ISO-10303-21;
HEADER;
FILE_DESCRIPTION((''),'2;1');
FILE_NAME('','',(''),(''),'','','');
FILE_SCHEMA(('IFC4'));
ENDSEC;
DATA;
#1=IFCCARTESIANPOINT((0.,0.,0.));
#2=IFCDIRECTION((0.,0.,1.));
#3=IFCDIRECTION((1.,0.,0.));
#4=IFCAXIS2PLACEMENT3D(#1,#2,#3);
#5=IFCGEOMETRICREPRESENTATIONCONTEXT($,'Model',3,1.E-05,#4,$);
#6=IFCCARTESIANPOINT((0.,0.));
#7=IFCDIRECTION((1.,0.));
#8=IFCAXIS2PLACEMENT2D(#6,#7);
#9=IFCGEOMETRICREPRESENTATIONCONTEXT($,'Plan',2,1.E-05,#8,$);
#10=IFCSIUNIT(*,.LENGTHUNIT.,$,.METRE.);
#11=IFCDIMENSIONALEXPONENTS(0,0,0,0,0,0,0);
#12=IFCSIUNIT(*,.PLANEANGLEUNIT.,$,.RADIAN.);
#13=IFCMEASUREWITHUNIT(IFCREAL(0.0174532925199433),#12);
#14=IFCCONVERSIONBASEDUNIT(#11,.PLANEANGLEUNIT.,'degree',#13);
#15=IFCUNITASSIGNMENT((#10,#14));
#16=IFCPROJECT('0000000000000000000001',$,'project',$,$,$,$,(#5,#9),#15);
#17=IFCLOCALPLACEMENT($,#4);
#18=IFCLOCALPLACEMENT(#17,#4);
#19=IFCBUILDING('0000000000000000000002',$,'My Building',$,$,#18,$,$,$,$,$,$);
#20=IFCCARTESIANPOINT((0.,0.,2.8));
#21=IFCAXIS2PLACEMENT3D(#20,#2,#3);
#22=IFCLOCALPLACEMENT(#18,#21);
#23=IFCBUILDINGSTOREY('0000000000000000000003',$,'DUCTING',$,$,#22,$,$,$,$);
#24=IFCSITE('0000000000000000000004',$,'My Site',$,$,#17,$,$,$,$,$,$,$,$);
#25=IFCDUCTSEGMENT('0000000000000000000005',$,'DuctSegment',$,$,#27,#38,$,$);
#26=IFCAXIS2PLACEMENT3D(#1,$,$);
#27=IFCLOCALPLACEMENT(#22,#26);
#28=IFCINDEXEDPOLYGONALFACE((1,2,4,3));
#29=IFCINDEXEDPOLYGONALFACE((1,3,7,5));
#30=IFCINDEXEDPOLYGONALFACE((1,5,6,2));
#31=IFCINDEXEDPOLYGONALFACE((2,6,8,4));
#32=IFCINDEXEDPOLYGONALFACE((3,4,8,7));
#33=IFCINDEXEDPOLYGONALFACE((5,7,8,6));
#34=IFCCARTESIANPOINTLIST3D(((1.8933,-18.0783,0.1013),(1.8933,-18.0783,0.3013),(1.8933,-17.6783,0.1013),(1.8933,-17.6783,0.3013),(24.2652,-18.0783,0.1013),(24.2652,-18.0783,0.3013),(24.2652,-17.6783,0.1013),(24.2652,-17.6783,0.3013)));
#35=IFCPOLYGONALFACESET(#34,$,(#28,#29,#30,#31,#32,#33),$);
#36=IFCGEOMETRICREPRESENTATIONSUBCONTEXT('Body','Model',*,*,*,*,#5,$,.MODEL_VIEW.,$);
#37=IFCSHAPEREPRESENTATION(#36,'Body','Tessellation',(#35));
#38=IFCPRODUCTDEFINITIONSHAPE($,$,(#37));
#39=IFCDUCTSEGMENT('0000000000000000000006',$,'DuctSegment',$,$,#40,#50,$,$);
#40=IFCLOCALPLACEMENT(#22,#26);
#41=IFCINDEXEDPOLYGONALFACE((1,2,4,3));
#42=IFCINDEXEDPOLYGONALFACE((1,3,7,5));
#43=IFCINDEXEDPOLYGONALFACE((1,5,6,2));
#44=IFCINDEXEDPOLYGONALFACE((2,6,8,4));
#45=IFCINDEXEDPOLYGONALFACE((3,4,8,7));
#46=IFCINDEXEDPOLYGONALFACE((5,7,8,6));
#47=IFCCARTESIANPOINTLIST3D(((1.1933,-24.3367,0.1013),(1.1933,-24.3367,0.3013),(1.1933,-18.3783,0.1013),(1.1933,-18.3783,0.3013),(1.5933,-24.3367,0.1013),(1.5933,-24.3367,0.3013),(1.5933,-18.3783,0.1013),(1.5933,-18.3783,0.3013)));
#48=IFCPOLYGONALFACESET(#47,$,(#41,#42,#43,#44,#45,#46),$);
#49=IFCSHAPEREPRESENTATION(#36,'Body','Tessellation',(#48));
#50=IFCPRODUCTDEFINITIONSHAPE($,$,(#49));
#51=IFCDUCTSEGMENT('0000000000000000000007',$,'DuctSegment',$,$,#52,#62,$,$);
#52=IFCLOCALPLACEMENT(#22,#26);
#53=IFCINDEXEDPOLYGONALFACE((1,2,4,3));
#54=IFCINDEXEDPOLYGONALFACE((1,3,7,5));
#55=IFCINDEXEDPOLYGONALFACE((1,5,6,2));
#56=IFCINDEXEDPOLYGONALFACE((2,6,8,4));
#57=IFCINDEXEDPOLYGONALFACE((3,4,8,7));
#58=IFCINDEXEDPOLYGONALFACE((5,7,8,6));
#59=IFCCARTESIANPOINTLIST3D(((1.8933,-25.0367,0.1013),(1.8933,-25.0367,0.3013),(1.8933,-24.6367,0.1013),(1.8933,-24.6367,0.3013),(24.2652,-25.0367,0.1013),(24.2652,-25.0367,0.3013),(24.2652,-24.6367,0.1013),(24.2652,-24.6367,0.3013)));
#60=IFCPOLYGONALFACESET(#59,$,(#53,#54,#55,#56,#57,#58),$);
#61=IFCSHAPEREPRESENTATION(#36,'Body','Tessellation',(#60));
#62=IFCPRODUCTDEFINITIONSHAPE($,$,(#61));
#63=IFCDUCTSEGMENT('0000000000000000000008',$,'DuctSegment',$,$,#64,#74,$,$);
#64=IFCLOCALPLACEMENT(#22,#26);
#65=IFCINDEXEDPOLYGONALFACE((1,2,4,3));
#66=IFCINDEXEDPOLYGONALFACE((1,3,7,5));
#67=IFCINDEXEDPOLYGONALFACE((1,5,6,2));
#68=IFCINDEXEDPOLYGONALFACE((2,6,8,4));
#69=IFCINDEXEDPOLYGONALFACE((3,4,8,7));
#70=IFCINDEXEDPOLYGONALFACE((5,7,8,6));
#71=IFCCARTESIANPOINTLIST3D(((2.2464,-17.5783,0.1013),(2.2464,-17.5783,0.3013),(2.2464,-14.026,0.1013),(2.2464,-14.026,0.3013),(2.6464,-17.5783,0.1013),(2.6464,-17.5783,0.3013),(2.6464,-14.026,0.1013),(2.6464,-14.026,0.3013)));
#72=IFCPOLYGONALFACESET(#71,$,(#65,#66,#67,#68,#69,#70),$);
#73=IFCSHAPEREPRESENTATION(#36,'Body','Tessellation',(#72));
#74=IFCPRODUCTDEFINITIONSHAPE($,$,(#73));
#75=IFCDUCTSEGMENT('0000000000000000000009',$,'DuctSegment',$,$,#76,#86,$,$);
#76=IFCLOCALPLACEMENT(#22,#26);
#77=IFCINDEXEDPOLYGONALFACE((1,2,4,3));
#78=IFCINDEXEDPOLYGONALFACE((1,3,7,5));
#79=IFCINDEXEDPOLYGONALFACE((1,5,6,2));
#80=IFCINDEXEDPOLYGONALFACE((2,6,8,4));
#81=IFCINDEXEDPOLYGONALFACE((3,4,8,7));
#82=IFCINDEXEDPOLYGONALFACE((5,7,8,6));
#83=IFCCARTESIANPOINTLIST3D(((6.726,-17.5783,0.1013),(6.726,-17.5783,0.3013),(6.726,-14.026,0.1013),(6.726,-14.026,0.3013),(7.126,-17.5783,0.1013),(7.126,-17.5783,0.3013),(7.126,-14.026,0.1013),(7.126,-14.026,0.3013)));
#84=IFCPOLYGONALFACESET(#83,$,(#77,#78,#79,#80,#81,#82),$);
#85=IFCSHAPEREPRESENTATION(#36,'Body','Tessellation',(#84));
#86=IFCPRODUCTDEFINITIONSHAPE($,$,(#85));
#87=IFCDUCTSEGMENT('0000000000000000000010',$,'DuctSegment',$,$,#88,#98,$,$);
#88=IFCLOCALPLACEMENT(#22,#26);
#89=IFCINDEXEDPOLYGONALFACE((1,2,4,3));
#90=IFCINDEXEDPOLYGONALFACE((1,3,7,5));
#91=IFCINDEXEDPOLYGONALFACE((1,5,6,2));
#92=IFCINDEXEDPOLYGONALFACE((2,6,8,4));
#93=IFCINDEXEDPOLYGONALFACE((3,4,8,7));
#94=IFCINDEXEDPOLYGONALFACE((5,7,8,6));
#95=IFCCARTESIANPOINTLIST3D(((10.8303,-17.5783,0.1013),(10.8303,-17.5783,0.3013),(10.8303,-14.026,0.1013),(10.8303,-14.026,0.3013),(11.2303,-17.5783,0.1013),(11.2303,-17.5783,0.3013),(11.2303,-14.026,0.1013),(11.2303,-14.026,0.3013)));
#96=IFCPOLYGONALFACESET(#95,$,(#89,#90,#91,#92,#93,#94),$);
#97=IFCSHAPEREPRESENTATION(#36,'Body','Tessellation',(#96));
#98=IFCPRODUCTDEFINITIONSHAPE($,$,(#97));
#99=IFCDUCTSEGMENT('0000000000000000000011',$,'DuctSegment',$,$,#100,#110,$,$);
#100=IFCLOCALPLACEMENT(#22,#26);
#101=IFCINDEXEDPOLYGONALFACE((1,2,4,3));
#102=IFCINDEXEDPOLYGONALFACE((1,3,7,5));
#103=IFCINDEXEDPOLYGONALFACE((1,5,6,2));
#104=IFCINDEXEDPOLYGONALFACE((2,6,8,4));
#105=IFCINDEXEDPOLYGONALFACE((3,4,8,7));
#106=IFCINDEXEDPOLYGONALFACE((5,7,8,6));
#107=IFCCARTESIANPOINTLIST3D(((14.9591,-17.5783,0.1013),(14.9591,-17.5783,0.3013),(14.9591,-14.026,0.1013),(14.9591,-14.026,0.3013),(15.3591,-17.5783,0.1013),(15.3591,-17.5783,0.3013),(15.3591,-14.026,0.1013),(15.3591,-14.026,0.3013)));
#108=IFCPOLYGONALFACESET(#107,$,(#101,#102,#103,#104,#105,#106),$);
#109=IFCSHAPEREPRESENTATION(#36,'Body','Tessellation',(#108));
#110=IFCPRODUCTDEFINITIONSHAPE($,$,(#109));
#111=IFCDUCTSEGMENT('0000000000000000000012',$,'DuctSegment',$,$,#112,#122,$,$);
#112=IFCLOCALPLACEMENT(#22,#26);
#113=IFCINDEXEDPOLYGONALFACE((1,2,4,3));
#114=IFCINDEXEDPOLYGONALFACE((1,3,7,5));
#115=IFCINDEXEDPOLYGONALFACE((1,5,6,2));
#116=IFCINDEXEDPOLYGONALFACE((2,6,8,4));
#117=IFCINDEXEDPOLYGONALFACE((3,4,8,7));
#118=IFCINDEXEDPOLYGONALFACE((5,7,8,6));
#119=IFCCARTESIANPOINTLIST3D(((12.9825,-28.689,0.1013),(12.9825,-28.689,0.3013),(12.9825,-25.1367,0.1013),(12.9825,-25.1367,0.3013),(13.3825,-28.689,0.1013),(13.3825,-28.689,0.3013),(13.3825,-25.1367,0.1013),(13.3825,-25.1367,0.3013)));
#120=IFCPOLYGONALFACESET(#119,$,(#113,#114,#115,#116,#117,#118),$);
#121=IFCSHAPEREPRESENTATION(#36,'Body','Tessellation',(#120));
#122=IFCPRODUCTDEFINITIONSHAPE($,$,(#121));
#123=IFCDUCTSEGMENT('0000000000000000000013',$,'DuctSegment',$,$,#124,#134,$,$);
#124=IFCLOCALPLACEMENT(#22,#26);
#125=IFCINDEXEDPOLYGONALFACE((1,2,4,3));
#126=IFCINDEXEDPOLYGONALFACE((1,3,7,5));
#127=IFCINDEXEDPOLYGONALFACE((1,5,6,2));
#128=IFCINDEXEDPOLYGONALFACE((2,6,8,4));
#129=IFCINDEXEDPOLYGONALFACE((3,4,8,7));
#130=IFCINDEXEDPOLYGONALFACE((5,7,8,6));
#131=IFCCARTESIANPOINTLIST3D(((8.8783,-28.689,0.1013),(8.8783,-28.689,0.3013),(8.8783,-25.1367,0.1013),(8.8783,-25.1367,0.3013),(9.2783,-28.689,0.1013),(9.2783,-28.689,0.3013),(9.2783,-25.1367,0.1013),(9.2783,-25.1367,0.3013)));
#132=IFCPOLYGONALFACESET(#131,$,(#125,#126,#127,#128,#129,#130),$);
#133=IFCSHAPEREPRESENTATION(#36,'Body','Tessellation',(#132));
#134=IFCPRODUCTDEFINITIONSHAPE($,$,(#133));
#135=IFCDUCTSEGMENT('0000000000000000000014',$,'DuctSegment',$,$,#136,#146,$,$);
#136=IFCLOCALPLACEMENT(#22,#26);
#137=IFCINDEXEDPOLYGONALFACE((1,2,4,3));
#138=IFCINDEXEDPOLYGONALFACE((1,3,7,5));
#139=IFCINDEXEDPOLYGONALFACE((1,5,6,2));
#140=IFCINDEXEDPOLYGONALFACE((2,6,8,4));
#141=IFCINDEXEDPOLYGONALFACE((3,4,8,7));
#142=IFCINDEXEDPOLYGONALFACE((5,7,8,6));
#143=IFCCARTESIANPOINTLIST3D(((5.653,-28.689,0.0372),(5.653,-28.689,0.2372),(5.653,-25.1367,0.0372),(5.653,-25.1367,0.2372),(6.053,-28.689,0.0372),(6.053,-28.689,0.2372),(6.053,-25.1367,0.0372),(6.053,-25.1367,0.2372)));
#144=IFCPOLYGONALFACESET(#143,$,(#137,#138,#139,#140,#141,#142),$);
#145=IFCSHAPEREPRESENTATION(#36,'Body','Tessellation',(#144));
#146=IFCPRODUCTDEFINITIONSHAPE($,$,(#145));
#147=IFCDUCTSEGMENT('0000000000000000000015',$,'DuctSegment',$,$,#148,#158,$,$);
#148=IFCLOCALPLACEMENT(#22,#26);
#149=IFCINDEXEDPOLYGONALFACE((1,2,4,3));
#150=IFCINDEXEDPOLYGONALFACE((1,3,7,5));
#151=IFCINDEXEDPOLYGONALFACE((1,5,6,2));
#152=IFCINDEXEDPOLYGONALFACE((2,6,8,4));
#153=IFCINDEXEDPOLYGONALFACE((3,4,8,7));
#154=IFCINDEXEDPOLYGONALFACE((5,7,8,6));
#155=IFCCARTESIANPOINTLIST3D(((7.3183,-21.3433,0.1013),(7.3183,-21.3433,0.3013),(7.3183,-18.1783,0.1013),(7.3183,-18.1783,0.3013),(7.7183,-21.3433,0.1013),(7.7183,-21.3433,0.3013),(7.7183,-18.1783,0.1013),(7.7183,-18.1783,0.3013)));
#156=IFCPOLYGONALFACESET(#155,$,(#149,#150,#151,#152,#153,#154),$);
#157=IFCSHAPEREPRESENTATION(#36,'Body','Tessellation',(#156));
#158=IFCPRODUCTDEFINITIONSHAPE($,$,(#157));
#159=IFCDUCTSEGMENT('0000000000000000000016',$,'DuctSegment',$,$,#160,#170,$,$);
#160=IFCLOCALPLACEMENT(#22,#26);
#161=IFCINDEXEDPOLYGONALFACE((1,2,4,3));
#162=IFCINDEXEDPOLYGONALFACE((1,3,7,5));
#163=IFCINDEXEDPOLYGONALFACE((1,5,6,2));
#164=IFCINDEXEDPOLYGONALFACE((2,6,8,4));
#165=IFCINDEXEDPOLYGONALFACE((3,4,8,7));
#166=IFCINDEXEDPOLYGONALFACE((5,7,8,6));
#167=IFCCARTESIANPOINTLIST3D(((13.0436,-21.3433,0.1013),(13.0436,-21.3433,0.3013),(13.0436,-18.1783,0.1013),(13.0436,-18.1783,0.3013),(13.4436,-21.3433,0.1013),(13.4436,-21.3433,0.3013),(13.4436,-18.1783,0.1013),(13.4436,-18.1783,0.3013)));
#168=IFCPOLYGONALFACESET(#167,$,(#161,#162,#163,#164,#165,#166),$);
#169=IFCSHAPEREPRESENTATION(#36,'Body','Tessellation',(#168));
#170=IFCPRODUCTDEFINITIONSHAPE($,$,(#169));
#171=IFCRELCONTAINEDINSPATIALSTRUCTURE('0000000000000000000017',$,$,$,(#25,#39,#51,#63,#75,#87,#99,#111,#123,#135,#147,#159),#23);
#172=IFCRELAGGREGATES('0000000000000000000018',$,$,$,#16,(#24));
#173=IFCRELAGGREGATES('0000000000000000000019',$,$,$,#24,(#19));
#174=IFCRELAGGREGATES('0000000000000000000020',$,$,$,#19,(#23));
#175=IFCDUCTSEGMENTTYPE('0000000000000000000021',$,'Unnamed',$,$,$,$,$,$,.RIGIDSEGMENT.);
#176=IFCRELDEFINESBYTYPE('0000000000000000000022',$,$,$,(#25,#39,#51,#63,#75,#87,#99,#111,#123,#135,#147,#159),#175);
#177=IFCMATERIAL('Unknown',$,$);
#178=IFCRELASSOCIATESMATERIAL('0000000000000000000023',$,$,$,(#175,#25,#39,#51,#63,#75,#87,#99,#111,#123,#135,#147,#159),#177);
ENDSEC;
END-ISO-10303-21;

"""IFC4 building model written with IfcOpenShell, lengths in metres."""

from ifc_helpers import new_model, entity, si_unit, converted_unit, frame, origin_with_axes, origin_2d_with_axis, place, context, subcontext, project, spatial, rectangle, extrude, material, material_profile, profile_set, profile_usage, type_object, element, save


model = new_model("IFC4")

# Units and contexts
model_context = context("Model", 3, precision=1e-05, world=origin_with_axes())
plan_context = context("Plan", 2, precision=1e-05, world=origin_2d_with_axis())
body_context = subcontext(model_context, "Body", "Model", "MODEL_VIEW")
ifc_project = project(units=[si_unit("LENGTHUNIT", "METRE"), converted_unit("PLANEANGLEUNIT", "degree", entity("IfcReal", 0.0174532925199433), si_unit("PLANEANGLEUNIT", "RADIAN"), dimensions=[0, 0, 0, 0, 0, 0, 0])], contexts=[model_context, plan_context])

# Site, building, storey
site_placement = place(None, origin_with_axes())
site = spatial("IfcSite", under=ifc_project, at=site_placement, Name="My Site")
building_placement = place(site_placement, origin_with_axes())
building = spatial("IfcBuilding", under=site, at=building_placement, Name="My Building")
storey_placement = place(building_placement, frame((0.0, 0.0, 2.8), z_axis=(0.0, 0.0, 1.0), x_axis=(1.0, 0.0, 0.0)))
storey = spatial("IfcBuildingStorey", under=building, at=storey_placement, Name="DUCTING")

# Duct segments
ifc_material = material(Name="Unknown")
ifc_material_profile_1 = material_profile(ifc_material, rectangle(XDim=0.4, YDim=0.2))
ifc_profile_set_1 = profile_set([ifc_material_profile_1])
ifc_profile_usage_1 = profile_usage(ifc_profile_set_1, cardinal=5)
duct_segment_type = type_object("IfcDuctSegmentType", Name="Unnamed", PredefinedType="RIGIDSEGMENT", material=ifc_profile_set_1)
duct_segment_1_placement = place(storey_placement, frame((1.8933, -17.8783, 0.2013), z_axis=(1.0, 0.0, 0.0), x_axis=(0.0, 1.0, 0.0)))
element("IfcDuctSegment", 1, at=duct_segment_1_placement, inside=storey, type_object=duct_segment_type, material=ifc_profile_usage_1, Name="DuctSegment", context=body_context, shape_type="SweptSolid", body=[
    extrude(rectangle(XDim=0.4, YDim=0.2), origin_with_axes(), (0.0, 0.0, 1.0), 22.3719),
])
ifc_profile_usage_2 = profile_usage(ifc_profile_set_1, cardinal=5)
duct_segment_2_placement = place(storey_placement, frame((1.3933, -18.3783, 0.2013), z_axis=(0.0, -1.0, 0.0), x_axis=(1.0, 0.0, 0.0)))
element("IfcDuctSegment", 2, at=duct_segment_2_placement, inside=storey, type_object=duct_segment_type, material=ifc_profile_usage_2, Name="DuctSegment", context=body_context, shape_type="SweptSolid", body=[
    extrude(rectangle(XDim=0.4, YDim=0.2), origin_with_axes(), (0.0, 0.0, 1.0), 5.9584),
])
ifc_profile_usage_3 = profile_usage(ifc_profile_set_1, cardinal=5)
duct_segment_3_placement = place(storey_placement, frame((1.8933, -24.8367, 0.2013), z_axis=(1.0, 0.0, 0.0), x_axis=(0.0, 1.0, 0.0)))
element("IfcDuctSegment", 3, at=duct_segment_3_placement, inside=storey, type_object=duct_segment_type, material=ifc_profile_usage_3, Name="DuctSegment", context=body_context, shape_type="SweptSolid", body=[
    extrude(rectangle(XDim=0.4, YDim=0.2), origin_with_axes(), (0.0, 0.0, 1.0), 22.3719),
])
ifc_profile_usage_4 = profile_usage(ifc_profile_set_1, cardinal=5)
duct_segment_4_placement = place(storey_placement, frame((2.4464, -17.5783, 0.2013), z_axis=(0.0, 1.0, 0.0), x_axis=(-1.0, 0.0, 0.0)))
element("IfcDuctSegment", 4, at=duct_segment_4_placement, inside=storey, type_object=duct_segment_type, material=ifc_profile_usage_4, Name="DuctSegment", context=body_context, shape_type="SweptSolid", body=[
    extrude(rectangle(XDim=0.4, YDim=0.2), origin_with_axes(), (0.0, 0.0, 1.0), 3.5523),
])
ifc_profile_usage_5 = profile_usage(ifc_profile_set_1, cardinal=5)
duct_segment_5_placement = place(storey_placement, frame((6.926, -17.5783, 0.2013), z_axis=(0.0, 1.0, 0.0), x_axis=(-1.0, 0.0, 0.0)))
element("IfcDuctSegment", 5, at=duct_segment_5_placement, inside=storey, type_object=duct_segment_type, material=ifc_profile_usage_5, Name="DuctSegment", context=body_context, shape_type="SweptSolid", body=[
    extrude(rectangle(XDim=0.4, YDim=0.2), origin_with_axes(), (0.0, 0.0, 1.0), 3.5523),
])
ifc_profile_usage_6 = profile_usage(ifc_profile_set_1, cardinal=5)
duct_segment_6_placement = place(storey_placement, frame((11.0303, -17.5783, 0.2013), z_axis=(0.0, 1.0, 0.0), x_axis=(-1.0, 0.0, 0.0)))
element("IfcDuctSegment", 6, at=duct_segment_6_placement, inside=storey, type_object=duct_segment_type, material=ifc_profile_usage_6, Name="DuctSegment", context=body_context, shape_type="SweptSolid", body=[
    extrude(rectangle(XDim=0.4, YDim=0.2), origin_with_axes(), (0.0, 0.0, 1.0), 3.5523),
])
ifc_profile_usage_7 = profile_usage(ifc_profile_set_1, cardinal=5)
duct_segment_7_placement = place(storey_placement, frame((15.1591, -17.5783, 0.2013), z_axis=(0.0, 1.0, 0.0), x_axis=(-1.0, 0.0, 0.0)))
element("IfcDuctSegment", 7, at=duct_segment_7_placement, inside=storey, type_object=duct_segment_type, material=ifc_profile_usage_7, Name="DuctSegment", context=body_context, shape_type="SweptSolid", body=[
    extrude(rectangle(XDim=0.4, YDim=0.2), origin_with_axes(), (0.0, 0.0, 1.0), 3.5523),
])
ifc_profile_usage_8 = profile_usage(ifc_profile_set_1, cardinal=5)
duct_segment_8_placement = place(storey_placement, frame((13.1825, -25.1367, 0.2013), z_axis=(0.0, -1.0, 0.0), x_axis=(1.0, 0.0, 0.0)))
element("IfcDuctSegment", 8, at=duct_segment_8_placement, inside=storey, type_object=duct_segment_type, material=ifc_profile_usage_8, Name="DuctSegment", context=body_context, shape_type="SweptSolid", body=[
    extrude(rectangle(XDim=0.4, YDim=0.2), origin_with_axes(), (0.0, 0.0, 1.0), 3.5523),
])
ifc_profile_usage_9 = profile_usage(ifc_profile_set_1, cardinal=5)
duct_segment_9_placement = place(storey_placement, frame((9.0783, -25.1367, 0.2013), z_axis=(0.0, -1.0, 0.0), x_axis=(1.0, 0.0, 0.0)))
element("IfcDuctSegment", 9, at=duct_segment_9_placement, inside=storey, type_object=duct_segment_type, material=ifc_profile_usage_9, Name="DuctSegment", context=body_context, shape_type="SweptSolid", body=[
    extrude(rectangle(XDim=0.4, YDim=0.2), origin_with_axes(), (0.0, 0.0, 1.0), 3.5523),
])
ifc_profile_usage_10 = profile_usage(ifc_profile_set_1, cardinal=5)
duct_segment_10_placement = place(storey_placement, frame((5.853, -25.1367, 0.1372), z_axis=(0.0, -1.0, 0.0), x_axis=(1.0, 0.0, 0.0)))
element("IfcDuctSegment", 10, at=duct_segment_10_placement, inside=storey, type_object=duct_segment_type, material=ifc_profile_usage_10, Name="DuctSegment", context=body_context, shape_type="SweptSolid", body=[
    extrude(rectangle(XDim=0.4, YDim=0.2), origin_with_axes(), (0.0, 0.0, 1.0), 3.5523),
])
ifc_profile_usage_11 = profile_usage(ifc_profile_set_1, cardinal=5)
duct_segment_11_placement = place(storey_placement, frame((7.5183, -18.1783, 0.2013), z_axis=(0.0, -1.0, 0.0), x_axis=(1.0, 0.0, 0.0)))
element("IfcDuctSegment", 11, at=duct_segment_11_placement, inside=storey, type_object=duct_segment_type, material=ifc_profile_usage_11, Name="DuctSegment", context=body_context, shape_type="SweptSolid", body=[
    extrude(rectangle(XDim=0.4, YDim=0.2), origin_with_axes(), (0.0, 0.0, 1.0), 3.165),
])
ifc_profile_usage_12 = profile_usage(ifc_profile_set_1, cardinal=5)
duct_segment_12_placement = place(storey_placement, frame((13.2436, -18.1783, 0.2013), z_axis=(0.0, -1.0, 0.0), x_axis=(1.0, 0.0, 0.0)))
element("IfcDuctSegment", 12, at=duct_segment_12_placement, inside=storey, type_object=duct_segment_type, material=ifc_profile_usage_12, Name="DuctSegment", context=body_context, shape_type="SweptSolid", body=[
    extrude(rectangle(XDim=0.4, YDim=0.2), origin_with_axes(), (0.0, 0.0, 1.0), 3.165),
])

save(model, "model.ifc")
